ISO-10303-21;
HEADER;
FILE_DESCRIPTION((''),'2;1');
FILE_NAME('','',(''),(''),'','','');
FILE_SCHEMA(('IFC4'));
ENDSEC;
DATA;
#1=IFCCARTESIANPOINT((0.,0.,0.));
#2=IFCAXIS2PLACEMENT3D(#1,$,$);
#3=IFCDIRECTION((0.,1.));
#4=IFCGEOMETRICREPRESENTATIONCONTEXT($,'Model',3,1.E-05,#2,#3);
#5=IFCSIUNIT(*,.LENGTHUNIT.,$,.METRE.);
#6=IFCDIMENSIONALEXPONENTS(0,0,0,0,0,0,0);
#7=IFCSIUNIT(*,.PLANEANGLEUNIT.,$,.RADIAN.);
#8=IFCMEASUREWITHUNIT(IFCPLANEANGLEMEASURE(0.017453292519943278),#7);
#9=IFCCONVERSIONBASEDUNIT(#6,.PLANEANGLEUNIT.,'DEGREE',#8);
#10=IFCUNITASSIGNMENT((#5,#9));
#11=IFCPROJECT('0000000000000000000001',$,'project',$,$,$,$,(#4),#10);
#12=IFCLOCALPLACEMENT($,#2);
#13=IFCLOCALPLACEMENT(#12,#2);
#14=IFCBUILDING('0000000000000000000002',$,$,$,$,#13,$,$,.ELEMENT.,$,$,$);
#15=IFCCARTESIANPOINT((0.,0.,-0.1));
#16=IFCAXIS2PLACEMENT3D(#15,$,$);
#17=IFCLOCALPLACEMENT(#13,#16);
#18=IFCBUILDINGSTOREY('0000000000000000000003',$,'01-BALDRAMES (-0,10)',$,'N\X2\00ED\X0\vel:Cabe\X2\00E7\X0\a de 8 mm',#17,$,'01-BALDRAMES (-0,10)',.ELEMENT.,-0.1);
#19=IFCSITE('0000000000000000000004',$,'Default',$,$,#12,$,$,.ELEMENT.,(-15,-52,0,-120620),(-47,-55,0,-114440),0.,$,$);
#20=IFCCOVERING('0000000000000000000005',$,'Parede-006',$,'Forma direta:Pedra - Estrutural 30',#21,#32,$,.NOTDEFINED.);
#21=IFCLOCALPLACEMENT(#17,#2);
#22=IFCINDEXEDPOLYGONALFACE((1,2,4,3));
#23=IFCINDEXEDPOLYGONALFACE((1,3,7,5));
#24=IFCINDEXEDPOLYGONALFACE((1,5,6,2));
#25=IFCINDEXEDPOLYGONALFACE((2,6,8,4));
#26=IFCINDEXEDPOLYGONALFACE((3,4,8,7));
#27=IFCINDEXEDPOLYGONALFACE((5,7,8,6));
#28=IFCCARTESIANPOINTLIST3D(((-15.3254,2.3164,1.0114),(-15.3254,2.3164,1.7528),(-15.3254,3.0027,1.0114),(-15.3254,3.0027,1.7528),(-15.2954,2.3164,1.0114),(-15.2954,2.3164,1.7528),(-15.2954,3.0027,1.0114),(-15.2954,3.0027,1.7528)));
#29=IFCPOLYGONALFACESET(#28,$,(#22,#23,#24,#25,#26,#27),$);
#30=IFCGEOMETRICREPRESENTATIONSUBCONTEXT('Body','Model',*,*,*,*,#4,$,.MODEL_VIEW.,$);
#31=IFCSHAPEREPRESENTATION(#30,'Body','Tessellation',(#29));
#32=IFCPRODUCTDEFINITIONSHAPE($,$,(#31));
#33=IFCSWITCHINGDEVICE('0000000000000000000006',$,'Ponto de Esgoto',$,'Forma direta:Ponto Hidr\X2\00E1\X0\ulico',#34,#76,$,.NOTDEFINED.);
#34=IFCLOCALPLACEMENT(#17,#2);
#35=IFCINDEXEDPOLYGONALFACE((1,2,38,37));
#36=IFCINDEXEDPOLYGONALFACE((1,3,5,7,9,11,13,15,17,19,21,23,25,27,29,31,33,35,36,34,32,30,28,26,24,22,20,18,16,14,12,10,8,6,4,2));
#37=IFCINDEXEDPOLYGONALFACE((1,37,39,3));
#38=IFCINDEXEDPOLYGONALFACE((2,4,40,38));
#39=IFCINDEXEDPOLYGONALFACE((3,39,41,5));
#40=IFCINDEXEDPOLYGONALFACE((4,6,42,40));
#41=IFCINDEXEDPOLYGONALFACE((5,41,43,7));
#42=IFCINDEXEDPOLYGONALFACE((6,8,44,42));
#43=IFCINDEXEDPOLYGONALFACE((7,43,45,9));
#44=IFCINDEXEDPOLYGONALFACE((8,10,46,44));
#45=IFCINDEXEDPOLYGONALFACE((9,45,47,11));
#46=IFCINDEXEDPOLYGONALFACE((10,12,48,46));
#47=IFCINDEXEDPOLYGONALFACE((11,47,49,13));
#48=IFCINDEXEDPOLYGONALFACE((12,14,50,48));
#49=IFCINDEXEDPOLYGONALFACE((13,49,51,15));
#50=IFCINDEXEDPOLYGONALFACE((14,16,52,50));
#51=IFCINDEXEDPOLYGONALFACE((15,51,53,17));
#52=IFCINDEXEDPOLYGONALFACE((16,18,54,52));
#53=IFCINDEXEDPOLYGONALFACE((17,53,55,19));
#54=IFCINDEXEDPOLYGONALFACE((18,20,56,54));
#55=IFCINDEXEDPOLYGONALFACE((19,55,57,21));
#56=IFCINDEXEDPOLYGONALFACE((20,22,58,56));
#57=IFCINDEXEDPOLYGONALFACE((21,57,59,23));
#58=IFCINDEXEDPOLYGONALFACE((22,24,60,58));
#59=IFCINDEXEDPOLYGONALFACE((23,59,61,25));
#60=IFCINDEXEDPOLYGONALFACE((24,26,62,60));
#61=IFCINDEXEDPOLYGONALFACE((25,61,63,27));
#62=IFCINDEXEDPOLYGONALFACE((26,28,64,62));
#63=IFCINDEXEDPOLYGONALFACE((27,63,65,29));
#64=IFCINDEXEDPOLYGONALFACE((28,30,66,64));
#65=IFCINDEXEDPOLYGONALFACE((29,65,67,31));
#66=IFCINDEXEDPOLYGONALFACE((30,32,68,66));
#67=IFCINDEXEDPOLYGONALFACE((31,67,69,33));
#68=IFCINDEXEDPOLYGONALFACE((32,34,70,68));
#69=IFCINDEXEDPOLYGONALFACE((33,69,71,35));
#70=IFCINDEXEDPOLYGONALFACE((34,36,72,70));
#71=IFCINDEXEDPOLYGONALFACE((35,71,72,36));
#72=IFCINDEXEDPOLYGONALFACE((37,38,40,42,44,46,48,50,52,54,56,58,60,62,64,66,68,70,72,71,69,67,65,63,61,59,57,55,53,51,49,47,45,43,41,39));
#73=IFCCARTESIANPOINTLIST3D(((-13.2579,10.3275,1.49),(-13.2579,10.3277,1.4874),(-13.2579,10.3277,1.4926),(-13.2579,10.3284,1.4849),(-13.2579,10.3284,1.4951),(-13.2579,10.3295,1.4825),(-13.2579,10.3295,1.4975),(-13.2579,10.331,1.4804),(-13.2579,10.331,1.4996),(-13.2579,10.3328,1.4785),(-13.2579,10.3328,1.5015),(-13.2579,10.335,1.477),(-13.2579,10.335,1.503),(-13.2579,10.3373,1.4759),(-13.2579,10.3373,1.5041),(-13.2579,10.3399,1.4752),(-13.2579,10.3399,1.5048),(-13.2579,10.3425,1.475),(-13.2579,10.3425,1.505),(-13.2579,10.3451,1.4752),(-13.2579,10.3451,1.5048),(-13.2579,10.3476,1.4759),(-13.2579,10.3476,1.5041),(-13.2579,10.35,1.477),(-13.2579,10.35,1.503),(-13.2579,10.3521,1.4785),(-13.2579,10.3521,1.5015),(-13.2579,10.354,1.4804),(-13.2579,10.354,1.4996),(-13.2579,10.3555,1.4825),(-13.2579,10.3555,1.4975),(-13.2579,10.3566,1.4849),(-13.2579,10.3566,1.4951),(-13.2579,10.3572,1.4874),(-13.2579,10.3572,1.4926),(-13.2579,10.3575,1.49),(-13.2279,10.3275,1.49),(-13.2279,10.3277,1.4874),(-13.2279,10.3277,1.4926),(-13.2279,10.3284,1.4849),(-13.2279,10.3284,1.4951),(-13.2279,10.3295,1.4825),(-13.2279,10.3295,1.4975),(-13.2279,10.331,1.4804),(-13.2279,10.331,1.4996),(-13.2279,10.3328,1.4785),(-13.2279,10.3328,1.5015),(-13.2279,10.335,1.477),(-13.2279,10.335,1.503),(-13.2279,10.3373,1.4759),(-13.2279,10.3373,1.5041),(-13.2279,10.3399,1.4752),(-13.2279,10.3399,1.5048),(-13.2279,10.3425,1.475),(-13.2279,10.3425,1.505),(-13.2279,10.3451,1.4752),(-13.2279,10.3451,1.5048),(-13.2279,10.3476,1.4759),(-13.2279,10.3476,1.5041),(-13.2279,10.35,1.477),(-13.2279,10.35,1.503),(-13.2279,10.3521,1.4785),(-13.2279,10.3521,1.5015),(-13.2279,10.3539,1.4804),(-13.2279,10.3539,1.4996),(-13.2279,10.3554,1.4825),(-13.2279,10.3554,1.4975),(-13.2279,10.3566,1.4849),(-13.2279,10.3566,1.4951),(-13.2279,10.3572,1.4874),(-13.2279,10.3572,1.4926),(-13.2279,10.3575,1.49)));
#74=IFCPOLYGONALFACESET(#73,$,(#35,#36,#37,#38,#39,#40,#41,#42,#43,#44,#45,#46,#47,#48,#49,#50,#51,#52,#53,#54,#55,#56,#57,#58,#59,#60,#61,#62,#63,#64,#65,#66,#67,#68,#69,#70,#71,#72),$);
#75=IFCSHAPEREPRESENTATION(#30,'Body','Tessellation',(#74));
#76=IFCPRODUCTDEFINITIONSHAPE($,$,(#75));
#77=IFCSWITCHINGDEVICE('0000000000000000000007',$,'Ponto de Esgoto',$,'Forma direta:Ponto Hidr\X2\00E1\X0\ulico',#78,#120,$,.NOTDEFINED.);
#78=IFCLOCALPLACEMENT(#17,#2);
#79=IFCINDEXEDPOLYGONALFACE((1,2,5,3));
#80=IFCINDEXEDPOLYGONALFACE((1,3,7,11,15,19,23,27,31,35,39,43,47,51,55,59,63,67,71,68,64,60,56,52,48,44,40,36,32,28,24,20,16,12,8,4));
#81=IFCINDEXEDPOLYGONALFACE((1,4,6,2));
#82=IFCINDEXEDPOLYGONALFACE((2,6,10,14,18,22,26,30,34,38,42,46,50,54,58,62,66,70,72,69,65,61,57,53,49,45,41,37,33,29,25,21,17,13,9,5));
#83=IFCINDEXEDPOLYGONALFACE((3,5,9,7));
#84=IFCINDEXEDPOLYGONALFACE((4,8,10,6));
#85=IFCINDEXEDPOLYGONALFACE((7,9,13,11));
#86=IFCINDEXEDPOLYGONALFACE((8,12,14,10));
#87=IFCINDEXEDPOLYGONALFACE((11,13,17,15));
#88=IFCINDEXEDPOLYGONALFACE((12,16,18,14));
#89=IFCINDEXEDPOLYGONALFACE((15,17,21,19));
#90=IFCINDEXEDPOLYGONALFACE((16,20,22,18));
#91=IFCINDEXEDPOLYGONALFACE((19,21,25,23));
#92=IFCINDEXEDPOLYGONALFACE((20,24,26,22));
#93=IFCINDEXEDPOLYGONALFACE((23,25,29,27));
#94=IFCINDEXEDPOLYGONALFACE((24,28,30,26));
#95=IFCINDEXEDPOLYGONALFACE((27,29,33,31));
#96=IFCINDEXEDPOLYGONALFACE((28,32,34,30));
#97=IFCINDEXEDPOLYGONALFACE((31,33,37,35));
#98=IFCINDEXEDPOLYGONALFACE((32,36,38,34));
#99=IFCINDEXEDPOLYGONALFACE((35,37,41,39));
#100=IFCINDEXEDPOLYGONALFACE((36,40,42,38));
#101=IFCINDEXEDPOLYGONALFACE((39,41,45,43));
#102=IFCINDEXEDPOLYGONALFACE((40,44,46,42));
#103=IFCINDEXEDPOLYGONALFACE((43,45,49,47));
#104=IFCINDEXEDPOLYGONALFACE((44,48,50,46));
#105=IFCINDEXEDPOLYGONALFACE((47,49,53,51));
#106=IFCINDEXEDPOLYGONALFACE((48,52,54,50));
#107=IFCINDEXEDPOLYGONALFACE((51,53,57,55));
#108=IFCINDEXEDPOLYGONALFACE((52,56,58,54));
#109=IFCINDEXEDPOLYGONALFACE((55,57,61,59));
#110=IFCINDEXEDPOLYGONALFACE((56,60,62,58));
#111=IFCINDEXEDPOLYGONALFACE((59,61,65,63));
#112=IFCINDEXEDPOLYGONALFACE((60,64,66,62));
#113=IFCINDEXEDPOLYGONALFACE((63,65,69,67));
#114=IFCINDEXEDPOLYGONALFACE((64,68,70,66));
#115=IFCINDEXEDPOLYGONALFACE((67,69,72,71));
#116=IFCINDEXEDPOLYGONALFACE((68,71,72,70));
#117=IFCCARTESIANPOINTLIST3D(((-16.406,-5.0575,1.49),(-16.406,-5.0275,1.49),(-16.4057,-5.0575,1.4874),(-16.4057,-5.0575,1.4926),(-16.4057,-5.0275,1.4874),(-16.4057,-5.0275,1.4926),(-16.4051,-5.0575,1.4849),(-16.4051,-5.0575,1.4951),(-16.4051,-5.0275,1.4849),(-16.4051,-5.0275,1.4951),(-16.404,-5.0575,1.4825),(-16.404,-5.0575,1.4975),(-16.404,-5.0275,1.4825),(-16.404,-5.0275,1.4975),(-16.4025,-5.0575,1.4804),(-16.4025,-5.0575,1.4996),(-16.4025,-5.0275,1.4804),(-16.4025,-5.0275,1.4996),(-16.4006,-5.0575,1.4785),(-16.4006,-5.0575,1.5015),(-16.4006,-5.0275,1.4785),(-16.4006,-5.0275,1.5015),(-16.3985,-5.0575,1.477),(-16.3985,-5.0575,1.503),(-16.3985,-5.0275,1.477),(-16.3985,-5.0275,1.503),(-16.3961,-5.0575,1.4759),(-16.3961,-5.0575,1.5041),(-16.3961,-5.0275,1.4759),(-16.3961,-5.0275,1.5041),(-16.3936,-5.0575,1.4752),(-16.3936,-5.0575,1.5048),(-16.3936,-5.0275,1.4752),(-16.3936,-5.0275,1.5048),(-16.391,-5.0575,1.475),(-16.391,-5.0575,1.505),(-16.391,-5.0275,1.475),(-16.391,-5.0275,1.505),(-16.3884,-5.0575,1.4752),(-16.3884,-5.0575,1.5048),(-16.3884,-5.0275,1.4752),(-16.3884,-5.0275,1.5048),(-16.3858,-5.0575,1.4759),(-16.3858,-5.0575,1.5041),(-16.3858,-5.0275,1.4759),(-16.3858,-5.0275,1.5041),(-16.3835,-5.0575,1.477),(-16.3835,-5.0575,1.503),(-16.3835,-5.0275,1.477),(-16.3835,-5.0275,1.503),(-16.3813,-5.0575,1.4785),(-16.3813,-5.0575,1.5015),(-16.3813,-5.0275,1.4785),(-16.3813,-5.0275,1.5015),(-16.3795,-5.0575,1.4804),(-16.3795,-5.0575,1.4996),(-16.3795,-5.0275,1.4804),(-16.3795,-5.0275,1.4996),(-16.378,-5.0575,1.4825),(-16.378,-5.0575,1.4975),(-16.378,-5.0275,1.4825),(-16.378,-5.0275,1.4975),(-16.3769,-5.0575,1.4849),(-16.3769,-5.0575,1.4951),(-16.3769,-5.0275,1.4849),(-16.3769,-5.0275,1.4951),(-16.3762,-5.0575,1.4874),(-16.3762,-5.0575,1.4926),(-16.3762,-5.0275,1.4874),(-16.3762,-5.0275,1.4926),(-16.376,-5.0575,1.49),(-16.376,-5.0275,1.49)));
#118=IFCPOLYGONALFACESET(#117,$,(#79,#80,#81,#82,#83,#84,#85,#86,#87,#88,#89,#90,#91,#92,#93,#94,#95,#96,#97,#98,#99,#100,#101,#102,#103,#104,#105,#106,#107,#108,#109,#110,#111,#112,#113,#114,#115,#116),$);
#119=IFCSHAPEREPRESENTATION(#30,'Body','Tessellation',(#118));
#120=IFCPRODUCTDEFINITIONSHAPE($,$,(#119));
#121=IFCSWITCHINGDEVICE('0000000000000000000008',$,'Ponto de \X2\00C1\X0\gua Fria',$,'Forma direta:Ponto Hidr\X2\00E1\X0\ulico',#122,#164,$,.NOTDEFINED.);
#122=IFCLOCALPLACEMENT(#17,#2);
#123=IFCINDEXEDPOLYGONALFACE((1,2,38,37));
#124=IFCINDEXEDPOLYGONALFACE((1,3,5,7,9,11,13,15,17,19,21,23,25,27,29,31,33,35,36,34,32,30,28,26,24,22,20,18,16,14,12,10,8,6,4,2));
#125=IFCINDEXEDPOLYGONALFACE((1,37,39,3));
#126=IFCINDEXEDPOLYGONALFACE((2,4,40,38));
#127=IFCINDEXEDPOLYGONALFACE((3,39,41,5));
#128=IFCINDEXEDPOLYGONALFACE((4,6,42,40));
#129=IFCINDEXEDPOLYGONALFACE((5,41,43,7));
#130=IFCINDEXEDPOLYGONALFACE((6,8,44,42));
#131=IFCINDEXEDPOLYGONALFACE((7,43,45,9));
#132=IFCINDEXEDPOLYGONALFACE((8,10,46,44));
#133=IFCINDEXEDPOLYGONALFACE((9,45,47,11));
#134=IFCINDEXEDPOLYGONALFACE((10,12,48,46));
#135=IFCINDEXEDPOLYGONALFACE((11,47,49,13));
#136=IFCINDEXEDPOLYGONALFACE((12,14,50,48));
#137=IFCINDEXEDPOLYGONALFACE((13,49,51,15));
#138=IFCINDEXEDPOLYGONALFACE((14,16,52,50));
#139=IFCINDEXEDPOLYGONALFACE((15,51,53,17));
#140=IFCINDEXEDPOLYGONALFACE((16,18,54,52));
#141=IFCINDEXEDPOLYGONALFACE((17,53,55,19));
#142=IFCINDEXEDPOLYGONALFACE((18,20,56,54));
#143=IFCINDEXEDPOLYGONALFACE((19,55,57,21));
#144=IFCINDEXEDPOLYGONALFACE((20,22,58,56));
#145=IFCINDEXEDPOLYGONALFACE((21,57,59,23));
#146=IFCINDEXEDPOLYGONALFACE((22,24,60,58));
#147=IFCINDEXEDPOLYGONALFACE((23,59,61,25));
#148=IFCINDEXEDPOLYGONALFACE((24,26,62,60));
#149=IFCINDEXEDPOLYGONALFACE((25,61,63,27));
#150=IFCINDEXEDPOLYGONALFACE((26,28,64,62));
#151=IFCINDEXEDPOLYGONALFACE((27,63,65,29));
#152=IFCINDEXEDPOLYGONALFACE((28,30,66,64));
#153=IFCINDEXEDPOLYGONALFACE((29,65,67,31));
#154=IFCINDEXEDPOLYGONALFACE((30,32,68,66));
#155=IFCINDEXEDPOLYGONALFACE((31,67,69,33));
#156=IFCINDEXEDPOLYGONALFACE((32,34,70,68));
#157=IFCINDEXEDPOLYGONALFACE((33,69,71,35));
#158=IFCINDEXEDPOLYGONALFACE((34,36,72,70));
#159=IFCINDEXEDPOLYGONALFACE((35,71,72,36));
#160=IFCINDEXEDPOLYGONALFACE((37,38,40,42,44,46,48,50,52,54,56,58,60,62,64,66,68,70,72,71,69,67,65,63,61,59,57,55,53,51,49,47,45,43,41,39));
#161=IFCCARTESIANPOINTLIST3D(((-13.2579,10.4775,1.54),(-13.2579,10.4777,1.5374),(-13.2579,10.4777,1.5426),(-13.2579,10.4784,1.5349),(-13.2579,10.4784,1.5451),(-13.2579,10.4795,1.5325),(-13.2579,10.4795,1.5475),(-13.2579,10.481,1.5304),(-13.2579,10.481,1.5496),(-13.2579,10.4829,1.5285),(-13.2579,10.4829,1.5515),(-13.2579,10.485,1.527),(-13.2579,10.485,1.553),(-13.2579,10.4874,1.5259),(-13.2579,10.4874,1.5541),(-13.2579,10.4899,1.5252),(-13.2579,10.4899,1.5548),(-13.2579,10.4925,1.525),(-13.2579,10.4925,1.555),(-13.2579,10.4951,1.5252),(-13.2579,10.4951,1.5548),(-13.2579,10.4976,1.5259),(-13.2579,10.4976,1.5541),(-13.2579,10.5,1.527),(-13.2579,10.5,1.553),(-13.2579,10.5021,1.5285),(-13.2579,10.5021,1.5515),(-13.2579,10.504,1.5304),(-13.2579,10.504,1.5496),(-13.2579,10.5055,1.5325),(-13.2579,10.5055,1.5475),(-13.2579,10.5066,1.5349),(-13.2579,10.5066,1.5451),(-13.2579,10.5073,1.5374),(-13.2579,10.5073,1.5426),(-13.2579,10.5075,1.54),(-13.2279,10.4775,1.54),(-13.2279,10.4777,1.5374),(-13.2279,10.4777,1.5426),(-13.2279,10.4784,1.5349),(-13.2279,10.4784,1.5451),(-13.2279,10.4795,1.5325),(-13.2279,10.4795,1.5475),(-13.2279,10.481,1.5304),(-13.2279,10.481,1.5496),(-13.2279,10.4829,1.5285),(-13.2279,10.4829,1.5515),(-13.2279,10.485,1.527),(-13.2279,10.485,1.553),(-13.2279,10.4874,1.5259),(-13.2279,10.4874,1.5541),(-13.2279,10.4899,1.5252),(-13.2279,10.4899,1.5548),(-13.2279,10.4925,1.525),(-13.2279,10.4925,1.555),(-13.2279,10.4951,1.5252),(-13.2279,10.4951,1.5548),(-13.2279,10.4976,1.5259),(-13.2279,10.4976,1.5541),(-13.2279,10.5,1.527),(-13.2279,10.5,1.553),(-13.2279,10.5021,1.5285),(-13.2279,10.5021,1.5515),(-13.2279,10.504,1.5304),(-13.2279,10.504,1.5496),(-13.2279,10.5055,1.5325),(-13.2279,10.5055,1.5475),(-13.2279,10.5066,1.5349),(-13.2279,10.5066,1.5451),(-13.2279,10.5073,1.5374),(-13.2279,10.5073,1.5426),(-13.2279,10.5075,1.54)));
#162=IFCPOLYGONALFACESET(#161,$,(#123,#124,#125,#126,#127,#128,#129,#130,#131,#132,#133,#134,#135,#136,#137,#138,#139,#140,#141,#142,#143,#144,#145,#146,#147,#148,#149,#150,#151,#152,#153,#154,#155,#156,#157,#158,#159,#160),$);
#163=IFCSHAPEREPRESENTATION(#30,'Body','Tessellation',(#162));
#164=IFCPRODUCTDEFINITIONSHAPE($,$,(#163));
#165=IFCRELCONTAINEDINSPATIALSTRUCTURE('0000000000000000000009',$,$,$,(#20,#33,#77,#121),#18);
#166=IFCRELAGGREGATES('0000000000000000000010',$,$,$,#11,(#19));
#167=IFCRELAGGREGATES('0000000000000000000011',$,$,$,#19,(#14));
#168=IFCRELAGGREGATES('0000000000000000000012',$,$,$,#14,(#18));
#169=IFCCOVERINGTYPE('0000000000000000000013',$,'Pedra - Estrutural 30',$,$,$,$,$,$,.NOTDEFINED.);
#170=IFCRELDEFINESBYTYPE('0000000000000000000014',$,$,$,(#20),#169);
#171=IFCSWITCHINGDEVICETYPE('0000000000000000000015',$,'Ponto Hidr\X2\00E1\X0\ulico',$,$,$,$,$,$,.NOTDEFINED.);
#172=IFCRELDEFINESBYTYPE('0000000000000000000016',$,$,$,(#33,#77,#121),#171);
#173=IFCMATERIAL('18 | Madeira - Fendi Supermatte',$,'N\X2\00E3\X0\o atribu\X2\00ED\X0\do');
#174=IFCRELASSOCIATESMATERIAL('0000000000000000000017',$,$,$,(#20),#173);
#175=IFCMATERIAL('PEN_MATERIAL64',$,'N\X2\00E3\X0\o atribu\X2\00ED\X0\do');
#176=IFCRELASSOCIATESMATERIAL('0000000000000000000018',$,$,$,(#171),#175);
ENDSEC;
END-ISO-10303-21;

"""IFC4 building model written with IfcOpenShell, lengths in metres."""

from ifc_helpers import new_model, entity, si_unit, converted_unit, direction, frame, origin, place, context, subcontext, project, spatial, indexed_curve, outline, extrude, material, type_object, element, save


model = new_model("IFC4")

# Units and contexts
model_context = context("Model", 3, precision=1e-05, world=origin(), true_north=direction((0.0, 1.0)))
body_context = subcontext(model_context, "Body", "Model", "MODEL_VIEW")
ifc_project = project(units=[si_unit("LENGTHUNIT", "METRE"), converted_unit("PLANEANGLEUNIT", "DEGREE", entity("IfcPlaneAngleMeasure", 0.017453292519943278), si_unit("PLANEANGLEUNIT", "RADIAN"), dimensions=[0, 0, 0, 0, 0, 0, 0])], contexts=[model_context])

# Site, building, storey
site_placement = place(None, origin())
site = spatial("IfcSite", under=ifc_project, at=site_placement, Name="Default", CompositionType="ELEMENT", RefLatitude=(-15, -52, 0, -120620), RefLongitude=(-47, -55, 0, -114440), RefElevation=0.0)
building_placement = place(site_placement, origin())
building = spatial("IfcBuilding", under=site, at=building_placement, CompositionType="ELEMENT")
storey_placement = place(building_placement, frame((0.0, 0.0, -0.1)))
storey = spatial("IfcBuildingStorey", under=building, at=storey_placement, Name="01-BALDRAMES (-0,10)", ObjectType="Nível:Cabeça de 8 mm", LongName="01-BALDRAMES (-0,10)", CompositionType="ELEMENT", Elevation=-0.1)

# Covering
ifc_material_1 = material(Name="18 | Madeira - Fendi Supermatte", Category="Não atribuído")
covering_type = type_object("IfcCoveringType", Name="Pedra - Estrutural 30", PredefinedType="NOTDEFINED")
covering_placement = place(storey_placement, origin())
element("IfcCovering", 1, at=covering_placement, inside=storey, type_object=covering_type, material=ifc_material_1, Name="Parede-006", ObjectType="Forma direta:Pedra - Estrutural 30", PredefinedType="NOTDEFINED", context=body_context, shape_type="SweptSolid", body=[
    extrude(outline(indexed_curve([(-0.015, -0.3431), (0.015, -0.3431), (0.015, 0.3431), (-0.015, 0.3431), (-0.015, -0.3431)], self_intersect=False)), frame((-15.3104, 2.6596, 1.0114)), (0.0, 0.0, 1.0), 0.7414),
])

# Switching devices
ifc_material_2 = material(Name="PEN_MATERIAL64", Category="Não atribuído")
switching_device_type = type_object("IfcSwitchingDeviceType", Name="Ponto Hidráulico", PredefinedType="NOTDEFINED", material=ifc_material_2)
switching_device_1_placement = place(storey_placement, origin())
element("IfcSwitchingDevice", 2, at=switching_device_1_placement, inside=storey, type_object=switching_device_type, Name="Ponto de Esgoto", ObjectType="Forma direta:Ponto Hidráulico", PredefinedType="NOTDEFINED", context=body_context, shape_type="SweptSolid", body=[
    extrude(outline(indexed_curve([(-0.0013, -0.0149), (0.0013, -0.0149), (0.0039, -0.0145), (0.0063, -0.0136), (0.0086, -0.0123), (0.0106, -0.0106), (0.0123, -0.0086), (0.0136, -0.0063), (0.0145, -0.0039), (0.0149, -0.0013), (0.0149, 0.0013), (0.0145, 0.0039), (0.0136, 0.0063), (0.0123, 0.0086), (0.0106, 0.0106), (0.0086, 0.0123), (0.0063, 0.0136), (0.0039, 0.0145), (0.0013, 0.0149), (-0.0013, 0.0149), (-0.0039, 0.0145), (-0.0063, 0.0136), (-0.0086, 0.0123), (-0.0106, 0.0106), (-0.0123, 0.0086), (-0.0136, 0.0063), (-0.0145, 0.0039), (-0.0149, 0.0013), (-0.0149, -0.0013), (-0.0145, -0.0039), (-0.0136, -0.0063), (-0.0123, -0.0086), (-0.0106, -0.0106), (-0.0086, -0.0123), (-0.0063, -0.0136), (-0.0039, -0.0145), (-0.0013, -0.0149)], self_intersect=False)), frame((-13.2579, 10.3425, 1.49), z_axis=(1.0, -0.000299, 0.0), x_axis=(0.000289, 0.965926, 0.258819)), (0.0, 0.0, 1.0), 0.03),
])
switching_device_2_placement = place(storey_placement, origin())
element("IfcSwitchingDevice", 3, at=switching_device_2_placement, inside=storey, type_object=switching_device_type, Name="Ponto de Esgoto", ObjectType="Forma direta:Ponto Hidráulico", PredefinedType="NOTDEFINED", context=body_context, shape_type="SweptSolid", body=[
    extrude(outline(indexed_curve([(-0.0013, -0.0149), (0.0013, -0.0149), (0.0039, -0.0145), (0.0063, -0.0136), (0.0086, -0.0123), (0.0106, -0.0106), (0.0123, -0.0086), (0.0136, -0.0063), (0.0145, -0.0039), (0.0149, -0.0013), (0.0149, 0.0013), (0.0145, 0.0039), (0.0136, 0.0063), (0.0123, 0.0086), (0.0106, 0.0106), (0.0086, 0.0123), (0.0063, 0.0136), (0.0039, 0.0145), (0.0013, 0.0149), (-0.0013, 0.0149), (-0.0039, 0.0145), (-0.0063, 0.0136), (-0.0086, 0.0123), (-0.0106, 0.0106), (-0.0123, 0.0086), (-0.0136, 0.0063), (-0.0145, 0.0039), (-0.0149, 0.0013), (-0.0149, -0.0013), (-0.0145, -0.0039), (-0.0136, -0.0063), (-0.0123, -0.0086), (-0.0106, -0.0106), (-0.0086, -0.0123), (-0.0063, -0.0136), (-0.0039, -0.0145), (-0.0013, -0.0149)], self_intersect=False)), frame((-16.391, -5.0575, 1.49), z_axis=(0.000435, 1.0, 0.0), x_axis=(-0.965926, 0.00042, 0.258819)), (0.0, 0.0, 1.0), 0.03),
])
switching_device_3_placement = place(storey_placement, origin())
element("IfcSwitchingDevice", 4, at=switching_device_3_placement, inside=storey, type_object=switching_device_type, Name="Ponto de Água Fria", ObjectType="Forma direta:Ponto Hidráulico", PredefinedType="NOTDEFINED", context=body_context, shape_type="SweptSolid", body=[
    extrude(outline(indexed_curve([(-0.0013, -0.0149), (0.0013, -0.0149), (0.0039, -0.0145), (0.0063, -0.0136), (0.0086, -0.0123), (0.0106, -0.0106), (0.0123, -0.0086), (0.0136, -0.0063), (0.0145, -0.0039), (0.0149, -0.0013), (0.0149, 0.0013), (0.0145, 0.0039), (0.0136, 0.0063), (0.0123, 0.0086), (0.0106, 0.0106), (0.0086, 0.0123), (0.0063, 0.0136), (0.0039, 0.0145), (0.0013, 0.0149), (-0.0013, 0.0149), (-0.0039, 0.0145), (-0.0063, 0.0136), (-0.0086, 0.0123), (-0.0106, 0.0106), (-0.0123, 0.0086), (-0.0136, 0.0063), (-0.0145, 0.0039), (-0.0149, 0.0013), (-0.0149, -0.0013), (-0.0145, -0.0039), (-0.0136, -0.0063), (-0.0123, -0.0086), (-0.0106, -0.0106), (-0.0086, -0.0123), (-0.0063, -0.0136), (-0.0039, -0.0145), (-0.0013, -0.0149)], self_intersect=False)), frame((-13.2579, 10.4925, 1.54), z_axis=(1.0, -0.000299, 0.0), x_axis=(0.000289, 0.965926, 0.258819)), (0.0, 0.0, 1.0), 0.03),
])

save(model, "model.ifc")
